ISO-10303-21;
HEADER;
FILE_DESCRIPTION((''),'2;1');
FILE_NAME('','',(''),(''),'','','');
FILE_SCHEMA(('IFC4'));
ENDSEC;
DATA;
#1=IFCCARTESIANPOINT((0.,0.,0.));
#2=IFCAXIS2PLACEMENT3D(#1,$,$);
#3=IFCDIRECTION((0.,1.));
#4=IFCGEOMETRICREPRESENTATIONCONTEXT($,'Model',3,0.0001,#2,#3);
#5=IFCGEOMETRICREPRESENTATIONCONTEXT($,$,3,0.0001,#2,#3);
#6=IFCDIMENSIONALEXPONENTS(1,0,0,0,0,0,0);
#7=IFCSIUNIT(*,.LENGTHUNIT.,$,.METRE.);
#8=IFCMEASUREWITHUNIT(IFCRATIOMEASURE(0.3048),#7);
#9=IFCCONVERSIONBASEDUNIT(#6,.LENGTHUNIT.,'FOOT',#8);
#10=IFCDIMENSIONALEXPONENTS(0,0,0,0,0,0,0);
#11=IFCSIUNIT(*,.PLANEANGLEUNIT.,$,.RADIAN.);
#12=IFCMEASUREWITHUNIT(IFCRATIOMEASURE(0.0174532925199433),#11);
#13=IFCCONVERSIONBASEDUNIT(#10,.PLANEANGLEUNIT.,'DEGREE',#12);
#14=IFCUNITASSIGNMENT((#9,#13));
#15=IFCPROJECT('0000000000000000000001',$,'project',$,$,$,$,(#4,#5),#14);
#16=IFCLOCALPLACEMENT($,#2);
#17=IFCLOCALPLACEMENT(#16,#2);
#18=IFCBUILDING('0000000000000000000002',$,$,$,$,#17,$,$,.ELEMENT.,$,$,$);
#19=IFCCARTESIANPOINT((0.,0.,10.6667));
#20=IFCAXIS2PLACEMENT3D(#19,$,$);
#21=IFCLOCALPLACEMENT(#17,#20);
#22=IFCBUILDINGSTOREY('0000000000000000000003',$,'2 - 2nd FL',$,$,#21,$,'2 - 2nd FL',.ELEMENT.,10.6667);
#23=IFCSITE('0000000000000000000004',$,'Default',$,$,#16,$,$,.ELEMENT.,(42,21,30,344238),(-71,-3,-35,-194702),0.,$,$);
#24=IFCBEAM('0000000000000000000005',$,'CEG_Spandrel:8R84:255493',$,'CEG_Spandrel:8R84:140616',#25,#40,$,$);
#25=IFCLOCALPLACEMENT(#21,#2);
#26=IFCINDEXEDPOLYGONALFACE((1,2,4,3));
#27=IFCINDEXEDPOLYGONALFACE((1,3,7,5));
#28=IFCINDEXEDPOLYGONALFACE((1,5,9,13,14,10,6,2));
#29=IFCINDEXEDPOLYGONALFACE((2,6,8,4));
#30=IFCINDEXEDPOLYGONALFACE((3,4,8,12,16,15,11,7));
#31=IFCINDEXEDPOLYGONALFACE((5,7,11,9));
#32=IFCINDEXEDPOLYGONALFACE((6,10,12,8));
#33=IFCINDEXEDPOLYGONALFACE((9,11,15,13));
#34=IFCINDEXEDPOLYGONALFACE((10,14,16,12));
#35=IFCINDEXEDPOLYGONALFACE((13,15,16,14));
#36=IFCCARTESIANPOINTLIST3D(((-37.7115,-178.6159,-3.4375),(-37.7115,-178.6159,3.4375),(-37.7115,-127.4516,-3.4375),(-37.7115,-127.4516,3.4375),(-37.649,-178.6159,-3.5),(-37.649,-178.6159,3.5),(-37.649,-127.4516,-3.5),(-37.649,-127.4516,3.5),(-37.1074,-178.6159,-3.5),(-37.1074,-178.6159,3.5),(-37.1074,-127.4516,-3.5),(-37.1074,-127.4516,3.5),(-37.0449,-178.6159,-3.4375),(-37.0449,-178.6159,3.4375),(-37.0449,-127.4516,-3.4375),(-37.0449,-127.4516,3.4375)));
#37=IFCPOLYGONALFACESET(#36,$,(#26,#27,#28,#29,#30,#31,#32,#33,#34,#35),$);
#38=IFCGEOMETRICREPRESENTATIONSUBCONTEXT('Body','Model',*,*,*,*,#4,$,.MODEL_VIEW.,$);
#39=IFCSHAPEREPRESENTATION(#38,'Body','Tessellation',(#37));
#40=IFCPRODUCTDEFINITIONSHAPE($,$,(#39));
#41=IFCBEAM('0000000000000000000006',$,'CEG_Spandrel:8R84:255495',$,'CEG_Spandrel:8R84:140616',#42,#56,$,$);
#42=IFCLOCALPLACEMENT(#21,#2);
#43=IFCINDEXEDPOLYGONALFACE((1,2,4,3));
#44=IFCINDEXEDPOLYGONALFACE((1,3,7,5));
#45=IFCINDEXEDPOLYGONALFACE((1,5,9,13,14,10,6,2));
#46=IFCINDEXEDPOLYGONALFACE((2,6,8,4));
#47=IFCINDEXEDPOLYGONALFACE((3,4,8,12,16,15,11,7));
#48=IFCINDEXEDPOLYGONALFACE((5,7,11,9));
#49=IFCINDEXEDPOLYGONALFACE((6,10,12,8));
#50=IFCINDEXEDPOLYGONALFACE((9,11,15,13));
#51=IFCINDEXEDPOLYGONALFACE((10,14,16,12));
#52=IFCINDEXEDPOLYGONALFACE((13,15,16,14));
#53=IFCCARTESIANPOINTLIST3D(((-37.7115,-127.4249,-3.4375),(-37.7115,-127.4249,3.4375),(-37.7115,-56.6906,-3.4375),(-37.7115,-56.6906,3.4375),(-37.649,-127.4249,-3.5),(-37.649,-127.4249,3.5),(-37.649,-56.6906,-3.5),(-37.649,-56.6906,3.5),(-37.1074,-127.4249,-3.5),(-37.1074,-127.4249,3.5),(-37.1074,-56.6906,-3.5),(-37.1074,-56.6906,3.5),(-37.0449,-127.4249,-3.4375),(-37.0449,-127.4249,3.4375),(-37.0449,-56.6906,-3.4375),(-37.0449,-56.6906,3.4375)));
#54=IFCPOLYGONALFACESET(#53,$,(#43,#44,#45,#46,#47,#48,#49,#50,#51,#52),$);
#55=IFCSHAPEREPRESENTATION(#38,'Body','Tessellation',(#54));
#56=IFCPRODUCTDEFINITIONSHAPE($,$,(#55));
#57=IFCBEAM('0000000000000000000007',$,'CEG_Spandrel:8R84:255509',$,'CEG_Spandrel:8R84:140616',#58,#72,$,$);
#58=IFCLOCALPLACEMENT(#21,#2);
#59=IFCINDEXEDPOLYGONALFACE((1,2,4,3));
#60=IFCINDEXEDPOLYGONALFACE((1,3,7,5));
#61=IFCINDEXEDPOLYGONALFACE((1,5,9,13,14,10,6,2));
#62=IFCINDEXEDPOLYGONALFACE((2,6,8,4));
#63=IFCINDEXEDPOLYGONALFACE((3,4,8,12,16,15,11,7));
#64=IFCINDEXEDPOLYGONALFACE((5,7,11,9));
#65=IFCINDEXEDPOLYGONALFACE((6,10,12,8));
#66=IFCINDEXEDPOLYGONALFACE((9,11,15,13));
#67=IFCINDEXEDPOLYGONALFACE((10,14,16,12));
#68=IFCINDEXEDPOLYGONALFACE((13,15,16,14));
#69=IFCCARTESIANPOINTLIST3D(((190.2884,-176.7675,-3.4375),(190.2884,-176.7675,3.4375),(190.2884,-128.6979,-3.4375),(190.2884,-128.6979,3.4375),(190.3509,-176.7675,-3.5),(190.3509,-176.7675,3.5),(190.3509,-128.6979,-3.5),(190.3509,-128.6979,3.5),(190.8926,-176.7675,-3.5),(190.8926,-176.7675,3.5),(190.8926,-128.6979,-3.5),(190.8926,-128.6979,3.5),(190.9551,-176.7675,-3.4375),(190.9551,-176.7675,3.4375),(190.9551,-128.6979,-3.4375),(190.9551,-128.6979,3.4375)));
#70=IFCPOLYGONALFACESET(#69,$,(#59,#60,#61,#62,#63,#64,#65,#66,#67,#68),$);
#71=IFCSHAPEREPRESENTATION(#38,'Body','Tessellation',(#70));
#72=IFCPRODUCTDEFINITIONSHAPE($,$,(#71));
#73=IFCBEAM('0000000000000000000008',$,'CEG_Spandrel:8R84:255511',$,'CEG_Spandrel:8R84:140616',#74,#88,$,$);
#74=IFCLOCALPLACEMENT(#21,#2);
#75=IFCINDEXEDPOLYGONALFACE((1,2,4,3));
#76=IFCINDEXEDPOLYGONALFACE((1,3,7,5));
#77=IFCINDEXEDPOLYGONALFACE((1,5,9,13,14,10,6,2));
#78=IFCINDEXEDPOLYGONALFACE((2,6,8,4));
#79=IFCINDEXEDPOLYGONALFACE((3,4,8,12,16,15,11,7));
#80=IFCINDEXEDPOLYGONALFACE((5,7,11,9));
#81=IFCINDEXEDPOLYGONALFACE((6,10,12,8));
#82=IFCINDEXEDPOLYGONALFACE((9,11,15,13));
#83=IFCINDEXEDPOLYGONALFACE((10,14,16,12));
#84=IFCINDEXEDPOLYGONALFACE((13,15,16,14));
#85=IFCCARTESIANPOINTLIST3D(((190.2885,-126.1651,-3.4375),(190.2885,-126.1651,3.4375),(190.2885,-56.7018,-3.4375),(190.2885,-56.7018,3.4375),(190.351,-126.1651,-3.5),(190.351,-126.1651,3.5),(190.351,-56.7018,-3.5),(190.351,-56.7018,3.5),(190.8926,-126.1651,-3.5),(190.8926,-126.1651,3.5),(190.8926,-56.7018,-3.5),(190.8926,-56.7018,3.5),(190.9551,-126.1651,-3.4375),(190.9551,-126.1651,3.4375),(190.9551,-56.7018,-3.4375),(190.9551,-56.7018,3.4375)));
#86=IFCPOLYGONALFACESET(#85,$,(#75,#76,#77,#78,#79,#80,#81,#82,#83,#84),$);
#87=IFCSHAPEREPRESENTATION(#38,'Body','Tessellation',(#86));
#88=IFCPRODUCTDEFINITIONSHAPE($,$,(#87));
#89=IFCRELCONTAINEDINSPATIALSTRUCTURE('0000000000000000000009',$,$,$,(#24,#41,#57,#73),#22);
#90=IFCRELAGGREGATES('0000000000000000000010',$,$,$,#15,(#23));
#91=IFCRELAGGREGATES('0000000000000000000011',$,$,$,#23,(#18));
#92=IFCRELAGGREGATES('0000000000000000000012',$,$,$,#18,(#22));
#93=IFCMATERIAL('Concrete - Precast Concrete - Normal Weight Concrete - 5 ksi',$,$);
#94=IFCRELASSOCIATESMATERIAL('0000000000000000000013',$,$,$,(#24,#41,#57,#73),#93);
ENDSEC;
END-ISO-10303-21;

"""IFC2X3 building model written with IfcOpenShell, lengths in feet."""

from ifc_helpers import new_model, entity, si_unit, converted_unit, direction, frame, origin, place, context, subcontext, project, spatial, polyline, outline, extrude, material, element, save


model = new_model("IFC2X3")

# Units and contexts
model_context = context("Model", 3, precision=0.0001, world=origin(), true_north=direction((0.0, 1.0)))
context_of_model = context(None, 3, precision=0.0001, world=origin(), true_north=direction((0.0, 1.0)))
body_context = subcontext(model_context, "Body", "Model", "MODEL_VIEW")
ifc_project = project(units=[converted_unit("LENGTHUNIT", "FOOT", entity("IfcRatioMeasure", 0.3048), si_unit("LENGTHUNIT", "METRE"), dimensions=[1, 0, 0, 0, 0, 0, 0]), converted_unit("PLANEANGLEUNIT", "DEGREE", entity("IfcRatioMeasure", 0.0174532925199433), si_unit("PLANEANGLEUNIT", "RADIAN"), dimensions=[0, 0, 0, 0, 0, 0, 0])], contexts=[model_context, context_of_model])

# Site, building, storey
site_placement = place(None, origin())
site = spatial("IfcSite", under=ifc_project, at=site_placement, Name="Default", CompositionType="ELEMENT", RefLatitude=(42, 21, 30, 344238), RefLongitude=(-71, -3, -35, -194702), RefElevation=0.0)
building_placement = place(site_placement, origin())
building = spatial("IfcBuilding", under=site, at=building_placement, CompositionType="ELEMENT")
storey_placement = place(building_placement, frame((0.0, 0.0, 10.6667)))
storey = spatial("IfcBuildingStorey", under=building, at=storey_placement, Name="2 - 2nd FL", LongName="2 - 2nd FL", CompositionType="ELEMENT", Elevation=10.6667)

# Beams
ifc_material = material(Name="Concrete - Precast Concrete - Normal Weight Concrete - 5 ksi")
beam_1_placement = place(storey_placement, frame((-37.3782, -177.3715, 3.5), z_axis=(0.0, 0.0, 1.0), x_axis=(0.0, 1.0, 0.0)))
element("IfcBeam", 1, at=beam_1_placement, inside=storey, material=ifc_material, Name="CEG_Spandrel:8R84:255493", ObjectType="CEG_Spandrel:8R84:140616", context=body_context, shape_type="SweptSolid", body=[
    extrude(outline(polyline([(-3.4375, -0.3333), (3.4375, -0.3333), (3.5, -0.2708), (3.5, 0.2708), (3.4375, 0.3333), (-3.4375, 0.3333), (-3.5, 0.2708), (-3.5, -0.2708), (-3.4375, -0.3333)])), frame((-1.2444, 0.0, -3.5), z_axis=(1.0, 0.0, 0.0), x_axis=(0.0, 0.0, -1.0)), (0.0, 0.0, 1.0), 51.1643),
])
beam_2_placement = place(storey_placement, frame((-37.3782, -127.2882, 3.5), z_axis=(0.0, 0.0, 1.0), x_axis=(0.0, 1.0, 0.0)))
element("IfcBeam", 2, at=beam_2_placement, inside=storey, material=ifc_material, Name="CEG_Spandrel:8R84:255495", ObjectType="CEG_Spandrel:8R84:140616", context=body_context, shape_type="SweptSolid", body=[
    extrude(outline(polyline([(-3.4375, -0.3333), (3.4375, -0.3333), (3.5, -0.2708), (3.5, 0.2708), (3.4375, 0.3333), (-3.4375, 0.3333), (-3.5, 0.2708), (-3.5, -0.2708), (-3.4375, -0.3333)])), frame((-0.1368, 0.0, -3.5), z_axis=(1.0, 0.0, 0.0), x_axis=(0.0, 0.0, -1.0)), (0.0, 0.0, 1.0), 70.7343),
])
beam_3_placement = place(storey_placement, frame((190.6218, -177.3715, 3.5), z_axis=(0.0, 0.0, 1.0), x_axis=(0.0, 1.0, 0.0)))
element("IfcBeam", 3, at=beam_3_placement, inside=storey, material=ifc_material, Name="CEG_Spandrel:8R84:255509", ObjectType="CEG_Spandrel:8R84:140616", context=body_context, shape_type="SweptSolid", body=[
    extrude(outline(polyline([(-3.4375, -0.3333), (3.4375, -0.3333), (3.5, -0.2708), (3.5, 0.2708), (3.4375, 0.3333), (-3.4375, 0.3333), (-3.5, 0.2708), (-3.5, -0.2708), (-3.4375, -0.3333)])), frame((0.604, 0.0, -3.5), z_axis=(1.0, 0.0, 0.0), x_axis=(0.0, 0.0, -1.0)), (0.0, 0.0, 1.0), 48.0697),
])
beam_4_placement = place(storey_placement, frame((190.6218, -127.2882, 3.5), z_axis=(0.0, 0.0, 1.0), x_axis=(0.0, 1.0, 0.0)))
element("IfcBeam", 4, at=beam_4_placement, inside=storey, material=ifc_material, Name="CEG_Spandrel:8R84:255511", ObjectType="CEG_Spandrel:8R84:140616", context=body_context, shape_type="SweptSolid", body=[
    extrude(outline(polyline([(-3.4375, -0.3333), (3.4375, -0.3333), (3.5, -0.2708), (3.5, 0.2708), (3.4375, 0.3333), (-3.4375, 0.3333), (-3.5, 0.2708), (-3.5, -0.2708), (-3.4375, -0.3333)])), frame((1.1231, 0.0, -3.5), z_axis=(1.0, 0.0, 0.0), x_axis=(0.0, 0.0, -1.0)), (0.0, 0.0, 1.0), 69.4633),
])

save(model, "model.ifc")
